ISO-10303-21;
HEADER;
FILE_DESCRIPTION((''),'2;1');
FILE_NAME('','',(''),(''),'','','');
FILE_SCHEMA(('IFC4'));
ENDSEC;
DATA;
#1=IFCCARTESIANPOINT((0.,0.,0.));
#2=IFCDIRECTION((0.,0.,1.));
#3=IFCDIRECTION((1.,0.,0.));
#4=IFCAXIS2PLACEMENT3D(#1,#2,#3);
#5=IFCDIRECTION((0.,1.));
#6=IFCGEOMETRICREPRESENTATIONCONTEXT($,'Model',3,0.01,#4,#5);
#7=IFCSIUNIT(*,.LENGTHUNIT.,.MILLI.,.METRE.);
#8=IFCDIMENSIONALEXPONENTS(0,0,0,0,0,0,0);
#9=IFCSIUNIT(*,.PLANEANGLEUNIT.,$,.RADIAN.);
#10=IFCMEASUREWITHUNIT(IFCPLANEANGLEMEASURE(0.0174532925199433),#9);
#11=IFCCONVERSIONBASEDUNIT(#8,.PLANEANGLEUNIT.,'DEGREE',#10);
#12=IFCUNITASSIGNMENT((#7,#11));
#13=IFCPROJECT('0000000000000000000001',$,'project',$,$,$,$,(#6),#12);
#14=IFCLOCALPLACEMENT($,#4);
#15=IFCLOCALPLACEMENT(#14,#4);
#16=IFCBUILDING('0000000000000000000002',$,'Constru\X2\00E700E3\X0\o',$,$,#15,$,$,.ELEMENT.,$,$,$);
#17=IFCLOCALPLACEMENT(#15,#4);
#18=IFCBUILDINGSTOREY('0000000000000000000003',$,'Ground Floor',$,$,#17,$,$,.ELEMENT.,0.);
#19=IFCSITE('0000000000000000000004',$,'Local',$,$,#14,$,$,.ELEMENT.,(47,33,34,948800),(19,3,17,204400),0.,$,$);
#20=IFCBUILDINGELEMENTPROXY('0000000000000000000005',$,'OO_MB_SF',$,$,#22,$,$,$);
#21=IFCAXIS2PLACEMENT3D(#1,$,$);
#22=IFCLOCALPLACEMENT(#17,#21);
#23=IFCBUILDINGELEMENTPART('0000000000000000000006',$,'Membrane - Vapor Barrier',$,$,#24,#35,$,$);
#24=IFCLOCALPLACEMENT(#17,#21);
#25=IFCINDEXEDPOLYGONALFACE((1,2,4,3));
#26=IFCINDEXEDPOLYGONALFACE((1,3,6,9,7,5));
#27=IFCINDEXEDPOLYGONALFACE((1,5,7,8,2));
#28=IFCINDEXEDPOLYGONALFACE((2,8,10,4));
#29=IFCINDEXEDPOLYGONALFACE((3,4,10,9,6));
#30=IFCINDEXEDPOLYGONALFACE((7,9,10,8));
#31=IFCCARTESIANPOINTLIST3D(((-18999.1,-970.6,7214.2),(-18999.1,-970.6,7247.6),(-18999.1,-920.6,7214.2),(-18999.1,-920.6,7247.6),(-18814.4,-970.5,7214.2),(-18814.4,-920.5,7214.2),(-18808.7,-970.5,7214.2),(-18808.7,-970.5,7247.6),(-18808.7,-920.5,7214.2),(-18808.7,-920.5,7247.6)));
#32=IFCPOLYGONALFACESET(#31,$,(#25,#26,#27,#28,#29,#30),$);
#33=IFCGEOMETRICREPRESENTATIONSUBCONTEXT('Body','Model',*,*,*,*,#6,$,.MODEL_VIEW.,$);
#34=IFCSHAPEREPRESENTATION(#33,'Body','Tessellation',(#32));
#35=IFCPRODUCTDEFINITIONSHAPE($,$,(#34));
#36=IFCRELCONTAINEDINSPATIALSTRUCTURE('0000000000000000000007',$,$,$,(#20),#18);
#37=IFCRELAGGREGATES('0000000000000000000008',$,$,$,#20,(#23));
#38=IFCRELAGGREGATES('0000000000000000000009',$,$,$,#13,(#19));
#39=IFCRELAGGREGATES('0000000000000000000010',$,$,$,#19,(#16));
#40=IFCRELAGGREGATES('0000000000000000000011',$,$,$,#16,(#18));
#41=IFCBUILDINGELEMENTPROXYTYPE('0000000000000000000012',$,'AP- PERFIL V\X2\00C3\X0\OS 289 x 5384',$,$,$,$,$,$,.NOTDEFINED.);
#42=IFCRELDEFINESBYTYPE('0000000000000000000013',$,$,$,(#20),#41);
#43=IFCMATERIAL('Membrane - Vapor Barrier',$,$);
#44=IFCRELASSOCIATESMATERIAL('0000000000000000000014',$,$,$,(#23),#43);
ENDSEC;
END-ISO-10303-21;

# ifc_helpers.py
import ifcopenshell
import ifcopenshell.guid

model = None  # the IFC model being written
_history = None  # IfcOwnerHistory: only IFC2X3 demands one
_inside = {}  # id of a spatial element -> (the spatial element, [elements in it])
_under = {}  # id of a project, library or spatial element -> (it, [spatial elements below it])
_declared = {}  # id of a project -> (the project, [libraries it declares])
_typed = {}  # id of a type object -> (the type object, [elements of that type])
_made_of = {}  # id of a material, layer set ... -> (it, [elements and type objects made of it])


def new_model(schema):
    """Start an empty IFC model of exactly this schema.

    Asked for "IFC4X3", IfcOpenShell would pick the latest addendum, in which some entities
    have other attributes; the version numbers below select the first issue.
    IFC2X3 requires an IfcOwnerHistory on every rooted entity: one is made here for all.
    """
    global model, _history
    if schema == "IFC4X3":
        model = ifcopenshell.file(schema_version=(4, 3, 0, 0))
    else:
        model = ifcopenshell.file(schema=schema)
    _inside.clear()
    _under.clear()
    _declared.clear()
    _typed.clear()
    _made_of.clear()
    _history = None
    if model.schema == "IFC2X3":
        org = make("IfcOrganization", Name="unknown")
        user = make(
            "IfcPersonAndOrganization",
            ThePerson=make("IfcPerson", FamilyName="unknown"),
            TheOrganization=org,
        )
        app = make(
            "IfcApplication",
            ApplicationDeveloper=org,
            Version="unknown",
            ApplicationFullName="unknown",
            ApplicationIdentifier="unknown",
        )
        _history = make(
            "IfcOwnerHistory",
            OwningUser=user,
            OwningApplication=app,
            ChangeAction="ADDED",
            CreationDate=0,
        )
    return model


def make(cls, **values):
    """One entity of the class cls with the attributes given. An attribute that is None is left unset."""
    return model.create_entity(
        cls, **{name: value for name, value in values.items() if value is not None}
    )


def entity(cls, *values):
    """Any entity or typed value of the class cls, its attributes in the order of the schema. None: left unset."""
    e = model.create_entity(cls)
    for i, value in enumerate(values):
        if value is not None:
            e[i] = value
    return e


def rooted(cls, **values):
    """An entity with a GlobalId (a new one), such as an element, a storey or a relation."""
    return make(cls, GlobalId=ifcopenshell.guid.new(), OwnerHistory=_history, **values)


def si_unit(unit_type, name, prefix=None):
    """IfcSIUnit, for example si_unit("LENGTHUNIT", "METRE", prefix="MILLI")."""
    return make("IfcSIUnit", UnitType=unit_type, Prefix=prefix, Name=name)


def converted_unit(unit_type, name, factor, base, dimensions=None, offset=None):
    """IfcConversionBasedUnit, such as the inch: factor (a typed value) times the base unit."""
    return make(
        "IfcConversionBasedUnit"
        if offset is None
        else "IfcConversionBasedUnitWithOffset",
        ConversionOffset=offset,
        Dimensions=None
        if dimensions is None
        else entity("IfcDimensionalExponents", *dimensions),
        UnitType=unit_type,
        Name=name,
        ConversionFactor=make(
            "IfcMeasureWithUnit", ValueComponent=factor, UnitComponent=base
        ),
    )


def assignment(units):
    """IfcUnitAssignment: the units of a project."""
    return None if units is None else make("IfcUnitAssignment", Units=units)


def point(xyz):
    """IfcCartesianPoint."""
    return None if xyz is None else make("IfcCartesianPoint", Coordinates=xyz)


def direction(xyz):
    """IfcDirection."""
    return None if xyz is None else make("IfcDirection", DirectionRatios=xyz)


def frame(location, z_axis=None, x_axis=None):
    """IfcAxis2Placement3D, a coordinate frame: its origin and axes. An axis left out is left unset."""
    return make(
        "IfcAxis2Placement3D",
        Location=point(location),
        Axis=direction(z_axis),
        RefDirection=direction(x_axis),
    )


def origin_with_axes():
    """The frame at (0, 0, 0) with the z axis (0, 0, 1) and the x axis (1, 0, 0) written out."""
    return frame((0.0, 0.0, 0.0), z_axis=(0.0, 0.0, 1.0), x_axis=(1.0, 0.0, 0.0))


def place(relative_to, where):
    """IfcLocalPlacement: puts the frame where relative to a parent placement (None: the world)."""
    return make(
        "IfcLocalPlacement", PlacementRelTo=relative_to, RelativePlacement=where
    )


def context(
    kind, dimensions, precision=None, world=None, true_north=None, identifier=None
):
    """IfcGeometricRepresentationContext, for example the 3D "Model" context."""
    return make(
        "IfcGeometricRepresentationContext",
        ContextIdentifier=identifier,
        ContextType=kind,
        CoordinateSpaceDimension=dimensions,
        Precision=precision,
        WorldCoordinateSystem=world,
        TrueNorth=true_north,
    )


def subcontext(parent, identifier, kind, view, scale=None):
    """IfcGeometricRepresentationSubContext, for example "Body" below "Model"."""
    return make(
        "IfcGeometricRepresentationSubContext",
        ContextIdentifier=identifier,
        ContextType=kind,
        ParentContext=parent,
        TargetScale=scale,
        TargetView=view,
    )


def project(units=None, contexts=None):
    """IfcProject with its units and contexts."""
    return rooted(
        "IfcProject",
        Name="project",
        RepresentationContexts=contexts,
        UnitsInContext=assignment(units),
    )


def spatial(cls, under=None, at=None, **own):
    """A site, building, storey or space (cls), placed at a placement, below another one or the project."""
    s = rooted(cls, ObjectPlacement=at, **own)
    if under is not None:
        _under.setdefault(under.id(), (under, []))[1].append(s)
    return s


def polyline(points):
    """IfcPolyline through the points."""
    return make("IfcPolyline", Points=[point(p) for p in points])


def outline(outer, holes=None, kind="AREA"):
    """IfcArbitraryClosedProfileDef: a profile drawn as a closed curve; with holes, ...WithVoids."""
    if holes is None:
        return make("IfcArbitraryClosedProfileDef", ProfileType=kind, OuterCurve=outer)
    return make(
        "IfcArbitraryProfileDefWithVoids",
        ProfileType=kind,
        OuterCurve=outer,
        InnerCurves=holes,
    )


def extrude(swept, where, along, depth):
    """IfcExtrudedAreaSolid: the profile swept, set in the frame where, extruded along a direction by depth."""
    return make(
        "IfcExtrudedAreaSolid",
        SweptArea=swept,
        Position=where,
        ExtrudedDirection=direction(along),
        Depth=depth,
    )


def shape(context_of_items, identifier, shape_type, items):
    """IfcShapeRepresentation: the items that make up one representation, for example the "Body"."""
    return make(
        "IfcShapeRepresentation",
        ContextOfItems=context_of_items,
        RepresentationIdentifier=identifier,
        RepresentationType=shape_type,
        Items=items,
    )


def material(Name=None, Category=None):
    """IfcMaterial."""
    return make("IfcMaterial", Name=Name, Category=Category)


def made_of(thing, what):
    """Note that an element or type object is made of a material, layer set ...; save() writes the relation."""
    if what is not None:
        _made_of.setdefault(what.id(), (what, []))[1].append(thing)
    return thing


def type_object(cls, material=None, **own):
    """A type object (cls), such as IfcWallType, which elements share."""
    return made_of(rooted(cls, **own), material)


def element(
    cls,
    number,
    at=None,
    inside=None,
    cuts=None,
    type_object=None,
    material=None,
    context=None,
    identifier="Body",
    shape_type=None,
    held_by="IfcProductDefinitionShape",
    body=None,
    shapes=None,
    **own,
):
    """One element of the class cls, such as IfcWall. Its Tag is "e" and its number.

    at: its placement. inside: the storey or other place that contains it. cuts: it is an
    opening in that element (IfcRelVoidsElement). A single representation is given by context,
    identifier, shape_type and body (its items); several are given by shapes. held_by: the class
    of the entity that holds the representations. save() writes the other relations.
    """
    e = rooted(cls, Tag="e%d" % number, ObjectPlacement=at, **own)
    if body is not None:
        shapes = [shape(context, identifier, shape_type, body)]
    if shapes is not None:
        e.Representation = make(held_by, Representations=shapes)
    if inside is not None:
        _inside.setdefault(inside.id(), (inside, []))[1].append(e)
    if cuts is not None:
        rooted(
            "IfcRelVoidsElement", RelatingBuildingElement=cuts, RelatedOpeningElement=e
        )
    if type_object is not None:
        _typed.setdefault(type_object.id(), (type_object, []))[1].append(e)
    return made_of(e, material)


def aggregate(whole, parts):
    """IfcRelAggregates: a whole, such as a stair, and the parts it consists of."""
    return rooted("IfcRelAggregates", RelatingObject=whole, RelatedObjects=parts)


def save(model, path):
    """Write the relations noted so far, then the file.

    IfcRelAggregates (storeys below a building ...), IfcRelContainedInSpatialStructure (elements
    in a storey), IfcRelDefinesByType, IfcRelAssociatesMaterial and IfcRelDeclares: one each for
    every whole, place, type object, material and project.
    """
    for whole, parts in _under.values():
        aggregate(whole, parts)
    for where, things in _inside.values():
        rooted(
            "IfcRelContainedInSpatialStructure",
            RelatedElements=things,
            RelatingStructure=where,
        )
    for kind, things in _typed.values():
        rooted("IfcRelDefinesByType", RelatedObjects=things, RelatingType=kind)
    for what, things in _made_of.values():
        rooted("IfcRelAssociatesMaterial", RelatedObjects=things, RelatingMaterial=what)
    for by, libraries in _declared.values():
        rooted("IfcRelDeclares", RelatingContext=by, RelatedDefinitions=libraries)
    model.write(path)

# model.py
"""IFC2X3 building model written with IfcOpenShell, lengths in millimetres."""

from ifc_helpers import new_model, entity, si_unit, converted_unit, direction, frame, origin_with_axes, place, context, subcontext, project, spatial, polyline, outline, extrude, material, type_object, element, aggregate, save


model = new_model("IFC2X3")

# Units and contexts
model_context = context("Model", 3, precision=0.01, world=origin_with_axes(), true_north=direction((0.0, 1.0)))
body_context = subcontext(model_context, "Body", "Model", "MODEL_VIEW")
ifc_project = project(units=[si_unit("LENGTHUNIT", "METRE", prefix="MILLI"), converted_unit("PLANEANGLEUNIT", "DEGREE", entity("IfcPlaneAngleMeasure", 0.0174532925199433), si_unit("PLANEANGLEUNIT", "RADIAN"), dimensions=[0, 0, 0, 0, 0, 0, 0])], contexts=[model_context])

# Site, building, storey
site_placement = place(None, origin_with_axes())
site = spatial("IfcSite", under=ifc_project, at=site_placement, Name="Local", CompositionType="ELEMENT", RefLatitude=(47, 33, 34, 948800), RefLongitude=(19, 3, 17, 204400), RefElevation=0.0)
building_placement = place(site_placement, origin_with_axes())
building = spatial("IfcBuilding", under=site, at=building_placement, Name="Construção", CompositionType="ELEMENT")
storey_placement = place(building_placement, origin_with_axes())
storey = spatial("IfcBuildingStorey", under=building, at=storey_placement, Name="Ground Floor", CompositionType="ELEMENT", Elevation=0.0)

# Building element proxy, building element part
building_element_proxy_type = type_object("IfcBuildingElementProxyType", Name="AP- PERFIL VÃOS 289 x 5384", PredefinedType="NOTDEFINED")
proxy_1_placement = place(storey_placement, frame((-18999.1, -970.6, 7247.6), z_axis=(0.0, 0.0, 1.0), x_axis=(1.0, 0.000322, 0.0)))
proxy_1 = element("IfcBuildingElementProxy", 1, at=proxy_1_placement, inside=storey, type_object=building_element_proxy_type, Name="OO_MB_SF")
ifc_material = material(Name="Membrane - Vapor Barrier")
building_element_part_1_placement = place(proxy_1_placement, origin_with_axes())
building_element_part_1 = element("IfcBuildingElementPart", 2, at=building_element_part_1_placement, material=ifc_material, Name="Membrane - Vapor Barrier", context=body_context, shape_type="SweptSolid", body=[
    extrude(outline(polyline([(190.4, 0.0), (0.0, 0.0), (0.0, -33.3), (184.7, -33.3), (190.4, -33.3), (190.4, 0.0)])), frame((0.0, 50.0, 0.0), z_axis=(0.0, -1.0, 0.0), x_axis=(1.0, 0.0, 0.0)), (0.0, 0.0, 1.0), 50.0),
])
aggregate(proxy_1, [building_element_part_1])

save(model, "model.ifc")
